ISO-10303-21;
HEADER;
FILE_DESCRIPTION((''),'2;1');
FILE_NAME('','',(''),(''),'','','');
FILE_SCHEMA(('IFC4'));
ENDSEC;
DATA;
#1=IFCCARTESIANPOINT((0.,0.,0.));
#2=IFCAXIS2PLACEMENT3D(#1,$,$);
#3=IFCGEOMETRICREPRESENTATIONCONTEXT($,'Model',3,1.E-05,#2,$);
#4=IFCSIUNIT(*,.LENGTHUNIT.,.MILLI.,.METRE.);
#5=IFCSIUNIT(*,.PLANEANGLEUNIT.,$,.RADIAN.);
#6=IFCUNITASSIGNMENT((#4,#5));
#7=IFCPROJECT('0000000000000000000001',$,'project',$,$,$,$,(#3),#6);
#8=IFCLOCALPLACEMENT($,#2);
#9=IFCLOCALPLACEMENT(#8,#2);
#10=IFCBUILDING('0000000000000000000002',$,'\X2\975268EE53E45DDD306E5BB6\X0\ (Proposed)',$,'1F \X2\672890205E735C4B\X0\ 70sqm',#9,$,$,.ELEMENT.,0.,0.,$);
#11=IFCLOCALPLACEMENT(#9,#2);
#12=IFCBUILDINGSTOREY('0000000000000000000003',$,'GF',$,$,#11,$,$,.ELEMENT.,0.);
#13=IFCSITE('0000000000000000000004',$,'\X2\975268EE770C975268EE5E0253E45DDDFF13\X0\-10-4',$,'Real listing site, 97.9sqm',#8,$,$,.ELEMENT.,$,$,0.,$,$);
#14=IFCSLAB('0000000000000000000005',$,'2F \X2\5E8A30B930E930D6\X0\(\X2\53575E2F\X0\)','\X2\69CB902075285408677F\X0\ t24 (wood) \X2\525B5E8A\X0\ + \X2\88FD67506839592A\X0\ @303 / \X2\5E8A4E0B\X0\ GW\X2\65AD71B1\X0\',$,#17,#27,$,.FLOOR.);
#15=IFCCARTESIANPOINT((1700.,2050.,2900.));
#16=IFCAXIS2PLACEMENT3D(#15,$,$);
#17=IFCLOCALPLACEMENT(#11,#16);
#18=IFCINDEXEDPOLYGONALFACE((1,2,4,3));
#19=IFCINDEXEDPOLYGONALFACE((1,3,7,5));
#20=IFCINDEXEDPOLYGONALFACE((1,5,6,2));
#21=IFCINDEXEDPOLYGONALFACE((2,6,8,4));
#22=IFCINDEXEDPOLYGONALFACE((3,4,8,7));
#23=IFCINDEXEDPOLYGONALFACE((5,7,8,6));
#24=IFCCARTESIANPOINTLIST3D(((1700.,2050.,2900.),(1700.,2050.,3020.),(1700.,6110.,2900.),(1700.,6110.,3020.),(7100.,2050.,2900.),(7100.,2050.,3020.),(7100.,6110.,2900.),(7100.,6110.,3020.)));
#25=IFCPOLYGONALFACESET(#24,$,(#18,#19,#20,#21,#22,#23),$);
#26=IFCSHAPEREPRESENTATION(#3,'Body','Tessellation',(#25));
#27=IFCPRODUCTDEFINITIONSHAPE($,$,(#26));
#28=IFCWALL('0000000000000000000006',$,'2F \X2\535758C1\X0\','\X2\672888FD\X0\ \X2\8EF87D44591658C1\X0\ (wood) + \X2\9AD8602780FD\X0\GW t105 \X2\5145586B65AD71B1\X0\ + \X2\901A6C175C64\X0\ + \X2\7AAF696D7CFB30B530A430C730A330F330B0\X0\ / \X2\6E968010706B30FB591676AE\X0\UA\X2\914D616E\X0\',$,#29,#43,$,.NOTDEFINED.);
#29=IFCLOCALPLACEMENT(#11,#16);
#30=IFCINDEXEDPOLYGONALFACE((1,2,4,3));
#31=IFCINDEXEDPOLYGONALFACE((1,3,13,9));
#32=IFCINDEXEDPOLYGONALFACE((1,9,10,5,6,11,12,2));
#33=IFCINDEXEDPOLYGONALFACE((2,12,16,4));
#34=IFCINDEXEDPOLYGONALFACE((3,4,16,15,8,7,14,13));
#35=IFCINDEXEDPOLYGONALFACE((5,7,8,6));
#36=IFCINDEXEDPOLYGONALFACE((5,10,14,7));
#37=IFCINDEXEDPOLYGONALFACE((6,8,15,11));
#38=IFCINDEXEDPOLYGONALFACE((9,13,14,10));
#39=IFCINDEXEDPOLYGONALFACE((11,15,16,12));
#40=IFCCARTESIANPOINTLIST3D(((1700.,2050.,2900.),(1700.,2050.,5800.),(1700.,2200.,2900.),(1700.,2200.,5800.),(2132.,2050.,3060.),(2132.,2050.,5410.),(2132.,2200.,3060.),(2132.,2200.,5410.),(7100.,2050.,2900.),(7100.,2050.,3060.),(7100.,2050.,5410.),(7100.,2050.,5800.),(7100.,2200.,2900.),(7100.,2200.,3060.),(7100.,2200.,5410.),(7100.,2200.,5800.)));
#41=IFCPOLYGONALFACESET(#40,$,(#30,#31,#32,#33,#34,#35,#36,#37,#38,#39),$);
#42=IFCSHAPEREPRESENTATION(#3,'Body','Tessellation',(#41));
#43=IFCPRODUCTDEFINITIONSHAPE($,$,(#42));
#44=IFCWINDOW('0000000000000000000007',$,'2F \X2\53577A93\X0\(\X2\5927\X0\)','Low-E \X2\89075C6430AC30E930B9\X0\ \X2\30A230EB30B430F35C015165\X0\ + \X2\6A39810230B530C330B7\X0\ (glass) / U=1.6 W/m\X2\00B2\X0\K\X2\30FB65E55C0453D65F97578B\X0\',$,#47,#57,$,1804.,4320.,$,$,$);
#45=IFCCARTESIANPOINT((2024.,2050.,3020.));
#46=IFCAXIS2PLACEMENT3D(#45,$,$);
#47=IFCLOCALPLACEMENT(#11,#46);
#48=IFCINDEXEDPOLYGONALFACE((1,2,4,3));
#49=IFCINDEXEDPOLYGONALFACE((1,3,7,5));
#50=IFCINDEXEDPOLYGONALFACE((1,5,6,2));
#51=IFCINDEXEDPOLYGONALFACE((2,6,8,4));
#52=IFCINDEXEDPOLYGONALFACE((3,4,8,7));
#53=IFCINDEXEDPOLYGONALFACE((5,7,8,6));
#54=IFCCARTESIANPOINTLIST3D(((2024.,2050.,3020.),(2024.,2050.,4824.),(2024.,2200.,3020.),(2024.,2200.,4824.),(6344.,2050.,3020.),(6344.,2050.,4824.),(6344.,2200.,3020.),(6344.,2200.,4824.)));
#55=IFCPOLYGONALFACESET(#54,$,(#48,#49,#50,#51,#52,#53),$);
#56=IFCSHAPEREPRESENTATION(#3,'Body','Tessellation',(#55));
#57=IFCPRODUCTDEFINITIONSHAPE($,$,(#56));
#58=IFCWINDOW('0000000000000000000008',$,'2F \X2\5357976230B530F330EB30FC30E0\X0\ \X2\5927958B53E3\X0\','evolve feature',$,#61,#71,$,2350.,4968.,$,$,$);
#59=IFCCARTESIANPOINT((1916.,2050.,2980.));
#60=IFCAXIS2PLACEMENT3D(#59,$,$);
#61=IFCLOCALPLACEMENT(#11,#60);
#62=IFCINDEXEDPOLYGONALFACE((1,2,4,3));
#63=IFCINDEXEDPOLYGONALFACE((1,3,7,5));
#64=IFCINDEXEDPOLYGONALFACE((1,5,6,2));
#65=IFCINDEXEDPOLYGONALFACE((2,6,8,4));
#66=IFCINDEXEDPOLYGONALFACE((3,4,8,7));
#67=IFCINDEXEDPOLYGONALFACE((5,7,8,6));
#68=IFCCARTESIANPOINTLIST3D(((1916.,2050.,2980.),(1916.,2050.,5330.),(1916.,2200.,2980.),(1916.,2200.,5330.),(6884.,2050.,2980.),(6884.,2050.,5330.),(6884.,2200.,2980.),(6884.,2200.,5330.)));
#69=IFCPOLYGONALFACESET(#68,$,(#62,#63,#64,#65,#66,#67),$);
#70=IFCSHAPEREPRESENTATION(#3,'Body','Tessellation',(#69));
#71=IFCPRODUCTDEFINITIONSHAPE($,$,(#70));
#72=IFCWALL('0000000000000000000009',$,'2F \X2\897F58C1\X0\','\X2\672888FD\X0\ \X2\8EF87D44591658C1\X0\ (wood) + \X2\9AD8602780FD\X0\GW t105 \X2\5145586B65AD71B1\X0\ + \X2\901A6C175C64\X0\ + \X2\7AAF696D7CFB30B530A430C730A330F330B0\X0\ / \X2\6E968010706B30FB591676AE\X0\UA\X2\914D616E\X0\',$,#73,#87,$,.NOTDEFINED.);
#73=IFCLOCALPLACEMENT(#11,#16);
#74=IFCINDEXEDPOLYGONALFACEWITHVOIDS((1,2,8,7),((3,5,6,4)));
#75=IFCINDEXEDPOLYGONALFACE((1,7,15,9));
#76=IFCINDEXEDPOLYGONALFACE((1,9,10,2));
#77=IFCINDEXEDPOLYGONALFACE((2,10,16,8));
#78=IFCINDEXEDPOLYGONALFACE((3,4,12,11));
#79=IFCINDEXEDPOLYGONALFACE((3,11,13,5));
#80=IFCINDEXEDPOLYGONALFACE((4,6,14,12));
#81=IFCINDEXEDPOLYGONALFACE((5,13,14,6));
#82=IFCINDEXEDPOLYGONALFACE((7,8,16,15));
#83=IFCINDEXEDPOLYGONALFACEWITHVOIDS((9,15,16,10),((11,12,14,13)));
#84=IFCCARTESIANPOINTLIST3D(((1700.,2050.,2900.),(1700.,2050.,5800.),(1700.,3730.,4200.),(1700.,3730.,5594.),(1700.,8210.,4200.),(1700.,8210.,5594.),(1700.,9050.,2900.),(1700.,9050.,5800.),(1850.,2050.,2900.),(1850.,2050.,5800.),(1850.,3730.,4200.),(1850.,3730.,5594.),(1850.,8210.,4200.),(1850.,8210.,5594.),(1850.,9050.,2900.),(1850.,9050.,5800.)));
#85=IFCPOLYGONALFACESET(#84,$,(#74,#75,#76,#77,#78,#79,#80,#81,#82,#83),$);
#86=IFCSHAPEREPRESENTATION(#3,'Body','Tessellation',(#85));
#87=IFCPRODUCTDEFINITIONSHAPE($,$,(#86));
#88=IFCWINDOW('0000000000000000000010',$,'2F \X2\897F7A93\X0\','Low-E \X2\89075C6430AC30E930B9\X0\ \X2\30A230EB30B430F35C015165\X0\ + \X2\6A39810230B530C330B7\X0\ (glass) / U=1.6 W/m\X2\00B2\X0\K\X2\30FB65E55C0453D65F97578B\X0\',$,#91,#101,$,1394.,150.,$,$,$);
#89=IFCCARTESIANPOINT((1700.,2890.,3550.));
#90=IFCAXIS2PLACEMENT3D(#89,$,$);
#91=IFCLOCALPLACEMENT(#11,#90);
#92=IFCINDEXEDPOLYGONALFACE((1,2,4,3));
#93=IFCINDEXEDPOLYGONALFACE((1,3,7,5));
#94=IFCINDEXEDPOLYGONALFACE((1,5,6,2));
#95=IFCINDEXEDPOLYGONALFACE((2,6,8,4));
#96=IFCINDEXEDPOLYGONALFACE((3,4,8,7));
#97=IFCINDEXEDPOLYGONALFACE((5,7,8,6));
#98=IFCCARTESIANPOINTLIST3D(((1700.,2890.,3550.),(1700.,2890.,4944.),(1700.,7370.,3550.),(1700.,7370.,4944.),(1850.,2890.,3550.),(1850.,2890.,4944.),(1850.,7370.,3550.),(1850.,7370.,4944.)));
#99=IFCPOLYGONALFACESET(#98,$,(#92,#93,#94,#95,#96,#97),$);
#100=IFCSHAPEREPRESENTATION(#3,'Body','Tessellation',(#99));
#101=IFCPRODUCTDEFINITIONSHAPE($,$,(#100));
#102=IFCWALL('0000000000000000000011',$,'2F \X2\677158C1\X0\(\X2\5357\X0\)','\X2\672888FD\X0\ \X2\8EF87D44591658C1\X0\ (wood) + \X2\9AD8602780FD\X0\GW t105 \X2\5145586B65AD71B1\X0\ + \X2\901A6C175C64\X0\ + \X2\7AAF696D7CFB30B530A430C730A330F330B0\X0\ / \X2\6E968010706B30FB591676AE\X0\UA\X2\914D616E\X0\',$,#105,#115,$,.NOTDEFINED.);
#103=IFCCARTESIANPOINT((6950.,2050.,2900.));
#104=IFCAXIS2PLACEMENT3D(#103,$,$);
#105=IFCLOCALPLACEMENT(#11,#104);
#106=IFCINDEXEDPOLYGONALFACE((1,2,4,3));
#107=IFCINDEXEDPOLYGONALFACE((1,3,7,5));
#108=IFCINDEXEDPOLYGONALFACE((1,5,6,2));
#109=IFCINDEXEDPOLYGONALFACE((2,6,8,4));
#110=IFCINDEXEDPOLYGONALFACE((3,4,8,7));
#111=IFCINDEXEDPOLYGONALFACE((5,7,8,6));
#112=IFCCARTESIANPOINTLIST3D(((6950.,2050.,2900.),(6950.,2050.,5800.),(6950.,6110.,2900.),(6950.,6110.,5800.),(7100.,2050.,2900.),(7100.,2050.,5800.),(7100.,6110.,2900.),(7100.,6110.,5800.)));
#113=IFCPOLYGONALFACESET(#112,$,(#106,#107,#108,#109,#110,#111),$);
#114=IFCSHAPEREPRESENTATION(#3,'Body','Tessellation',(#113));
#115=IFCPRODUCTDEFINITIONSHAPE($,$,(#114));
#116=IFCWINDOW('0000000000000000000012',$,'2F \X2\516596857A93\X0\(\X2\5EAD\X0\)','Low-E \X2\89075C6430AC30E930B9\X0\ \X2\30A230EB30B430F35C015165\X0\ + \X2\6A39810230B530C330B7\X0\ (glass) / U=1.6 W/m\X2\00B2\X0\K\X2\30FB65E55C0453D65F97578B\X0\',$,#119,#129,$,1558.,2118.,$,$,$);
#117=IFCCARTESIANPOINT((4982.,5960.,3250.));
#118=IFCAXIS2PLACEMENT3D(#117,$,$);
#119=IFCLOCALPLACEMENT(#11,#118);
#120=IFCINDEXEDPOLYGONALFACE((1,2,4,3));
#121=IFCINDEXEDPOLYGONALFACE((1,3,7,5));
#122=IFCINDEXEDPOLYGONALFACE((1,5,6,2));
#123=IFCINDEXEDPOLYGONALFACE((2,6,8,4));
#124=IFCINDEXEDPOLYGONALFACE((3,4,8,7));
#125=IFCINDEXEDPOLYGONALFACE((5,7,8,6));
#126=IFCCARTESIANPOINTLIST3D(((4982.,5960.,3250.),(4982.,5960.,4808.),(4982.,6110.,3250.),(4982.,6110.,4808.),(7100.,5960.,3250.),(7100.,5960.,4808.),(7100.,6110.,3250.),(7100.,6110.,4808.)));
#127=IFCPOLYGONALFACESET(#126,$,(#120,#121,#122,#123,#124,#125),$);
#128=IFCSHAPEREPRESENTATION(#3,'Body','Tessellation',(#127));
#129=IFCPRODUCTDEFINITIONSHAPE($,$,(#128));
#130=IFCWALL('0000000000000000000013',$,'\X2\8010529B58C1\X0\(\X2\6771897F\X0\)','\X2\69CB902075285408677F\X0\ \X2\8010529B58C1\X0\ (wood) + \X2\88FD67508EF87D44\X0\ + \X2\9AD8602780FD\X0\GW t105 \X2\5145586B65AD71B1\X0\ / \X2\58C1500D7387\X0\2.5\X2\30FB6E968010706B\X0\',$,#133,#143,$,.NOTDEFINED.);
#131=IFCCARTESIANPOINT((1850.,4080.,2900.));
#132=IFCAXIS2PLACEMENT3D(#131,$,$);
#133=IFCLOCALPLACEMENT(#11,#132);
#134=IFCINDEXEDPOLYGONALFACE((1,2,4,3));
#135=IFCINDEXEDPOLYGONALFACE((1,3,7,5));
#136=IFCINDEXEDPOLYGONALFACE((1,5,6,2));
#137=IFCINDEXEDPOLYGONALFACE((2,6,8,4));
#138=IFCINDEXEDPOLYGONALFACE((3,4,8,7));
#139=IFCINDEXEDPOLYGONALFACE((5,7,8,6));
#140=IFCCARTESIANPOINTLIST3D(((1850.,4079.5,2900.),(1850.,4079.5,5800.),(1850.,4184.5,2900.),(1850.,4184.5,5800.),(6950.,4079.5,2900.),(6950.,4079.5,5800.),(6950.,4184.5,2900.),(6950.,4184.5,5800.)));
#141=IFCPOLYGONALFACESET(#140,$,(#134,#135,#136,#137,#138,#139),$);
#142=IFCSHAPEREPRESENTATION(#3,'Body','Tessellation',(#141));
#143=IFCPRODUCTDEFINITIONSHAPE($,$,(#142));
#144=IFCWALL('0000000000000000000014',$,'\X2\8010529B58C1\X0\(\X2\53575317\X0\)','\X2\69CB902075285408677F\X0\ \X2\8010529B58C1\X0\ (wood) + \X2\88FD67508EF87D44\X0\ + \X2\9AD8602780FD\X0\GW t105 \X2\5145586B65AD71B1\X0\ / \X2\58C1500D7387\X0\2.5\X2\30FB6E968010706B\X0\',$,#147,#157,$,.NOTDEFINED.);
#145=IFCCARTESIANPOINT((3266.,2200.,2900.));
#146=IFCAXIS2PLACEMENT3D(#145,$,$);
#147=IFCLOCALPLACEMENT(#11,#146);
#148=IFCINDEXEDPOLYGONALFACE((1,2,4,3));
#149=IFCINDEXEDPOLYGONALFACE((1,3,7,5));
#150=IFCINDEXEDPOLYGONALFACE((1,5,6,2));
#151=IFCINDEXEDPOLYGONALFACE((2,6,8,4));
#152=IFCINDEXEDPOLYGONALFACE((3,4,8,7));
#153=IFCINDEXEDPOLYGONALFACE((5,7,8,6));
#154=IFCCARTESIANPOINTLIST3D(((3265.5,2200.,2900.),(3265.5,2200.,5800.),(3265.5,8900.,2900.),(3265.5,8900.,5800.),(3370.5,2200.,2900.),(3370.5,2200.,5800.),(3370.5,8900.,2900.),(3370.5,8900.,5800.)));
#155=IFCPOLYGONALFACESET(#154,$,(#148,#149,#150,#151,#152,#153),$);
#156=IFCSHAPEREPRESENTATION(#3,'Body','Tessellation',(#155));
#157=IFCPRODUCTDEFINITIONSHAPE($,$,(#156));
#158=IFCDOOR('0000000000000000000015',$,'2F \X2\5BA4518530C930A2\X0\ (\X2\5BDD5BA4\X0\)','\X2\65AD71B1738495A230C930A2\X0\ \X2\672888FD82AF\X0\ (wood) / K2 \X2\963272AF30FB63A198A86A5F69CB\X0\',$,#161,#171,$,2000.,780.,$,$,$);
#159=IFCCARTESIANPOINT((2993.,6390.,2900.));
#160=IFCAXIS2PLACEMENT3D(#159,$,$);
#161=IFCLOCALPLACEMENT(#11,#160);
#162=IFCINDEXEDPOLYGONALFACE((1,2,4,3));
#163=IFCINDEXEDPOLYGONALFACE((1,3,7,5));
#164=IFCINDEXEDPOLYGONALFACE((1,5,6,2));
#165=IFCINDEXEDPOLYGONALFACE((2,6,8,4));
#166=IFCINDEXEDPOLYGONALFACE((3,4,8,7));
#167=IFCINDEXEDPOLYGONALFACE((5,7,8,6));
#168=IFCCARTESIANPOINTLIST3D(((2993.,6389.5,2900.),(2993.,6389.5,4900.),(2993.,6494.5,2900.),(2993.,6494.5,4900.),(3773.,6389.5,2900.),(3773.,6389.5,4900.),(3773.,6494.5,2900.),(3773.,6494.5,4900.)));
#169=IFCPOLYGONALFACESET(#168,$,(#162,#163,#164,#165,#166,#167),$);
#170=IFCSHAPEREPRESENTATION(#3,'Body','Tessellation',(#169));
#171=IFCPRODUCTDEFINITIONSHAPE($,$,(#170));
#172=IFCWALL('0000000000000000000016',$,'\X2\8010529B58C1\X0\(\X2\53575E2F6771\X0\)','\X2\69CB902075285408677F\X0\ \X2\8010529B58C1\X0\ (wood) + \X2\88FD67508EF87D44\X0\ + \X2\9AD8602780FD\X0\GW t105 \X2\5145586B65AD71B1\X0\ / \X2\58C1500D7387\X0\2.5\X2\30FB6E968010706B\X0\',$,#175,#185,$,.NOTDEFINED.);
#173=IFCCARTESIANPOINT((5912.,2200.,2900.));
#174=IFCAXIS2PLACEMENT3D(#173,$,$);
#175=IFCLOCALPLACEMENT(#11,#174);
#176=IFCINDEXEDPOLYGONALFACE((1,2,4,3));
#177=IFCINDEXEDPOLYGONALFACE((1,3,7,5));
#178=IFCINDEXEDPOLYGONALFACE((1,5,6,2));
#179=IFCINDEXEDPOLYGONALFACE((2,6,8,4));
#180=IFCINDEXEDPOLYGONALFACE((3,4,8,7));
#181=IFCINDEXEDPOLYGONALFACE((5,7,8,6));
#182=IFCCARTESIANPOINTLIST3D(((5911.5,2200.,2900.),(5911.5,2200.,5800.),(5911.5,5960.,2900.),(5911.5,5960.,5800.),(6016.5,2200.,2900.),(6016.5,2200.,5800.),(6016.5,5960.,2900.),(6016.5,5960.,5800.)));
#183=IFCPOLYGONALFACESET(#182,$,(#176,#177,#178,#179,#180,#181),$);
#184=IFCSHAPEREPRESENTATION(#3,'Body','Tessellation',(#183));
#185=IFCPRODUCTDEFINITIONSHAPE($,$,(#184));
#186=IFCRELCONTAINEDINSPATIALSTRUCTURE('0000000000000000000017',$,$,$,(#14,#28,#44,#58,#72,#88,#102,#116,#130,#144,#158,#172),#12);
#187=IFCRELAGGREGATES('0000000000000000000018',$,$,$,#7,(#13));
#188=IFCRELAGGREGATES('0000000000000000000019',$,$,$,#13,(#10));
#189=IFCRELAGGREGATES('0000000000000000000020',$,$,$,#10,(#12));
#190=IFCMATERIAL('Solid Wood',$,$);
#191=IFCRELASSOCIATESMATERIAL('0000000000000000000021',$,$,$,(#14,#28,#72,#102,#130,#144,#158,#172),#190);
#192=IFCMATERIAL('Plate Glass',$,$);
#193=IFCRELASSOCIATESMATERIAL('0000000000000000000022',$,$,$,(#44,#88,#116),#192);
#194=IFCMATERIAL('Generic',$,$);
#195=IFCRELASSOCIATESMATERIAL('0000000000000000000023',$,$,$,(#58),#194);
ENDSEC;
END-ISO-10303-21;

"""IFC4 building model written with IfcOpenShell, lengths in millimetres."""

from ifc_helpers import new_model, si_unit, frame, frame_2d, origin, place, context, project, spatial, rectangle, extrude, material, element, fill, save


model = new_model("IFC4")

# Units and contexts
model_context = context("Model", 3, precision=1e-05, world=origin())
ifc_project = project(units=[si_unit("LENGTHUNIT", "METRE", prefix="MILLI"), si_unit("PLANEANGLEUNIT", "RADIAN")], contexts=[model_context])

# Site, building, storey
site_placement = place(None, origin())
site = spatial("IfcSite", under=ifc_project, at=site_placement, Name="青森県青森市古川３-10-4", ObjectType="Real listing site, 97.9sqm", CompositionType="ELEMENT", RefElevation=0.0)
building_placement = place(site_placement, origin())
building = spatial("IfcBuilding", under=site, at=building_placement, Name="青森古川の家 (Proposed)", ObjectType="1F 木造平屋 70sqm", CompositionType="ELEMENT", ElevationOfRefHeight=0.0, ElevationOfTerrain=0.0)
storey_placement = place(building_placement, origin())
storey = spatial("IfcBuildingStorey", under=building, at=storey_placement, Name="GF", CompositionType="ELEMENT", Elevation=0.0)

# Slab
ifc_material_1 = material(Name="Solid Wood")
slab_placement = place(storey_placement, frame((1700.0, 2050.0, 2900.0)))
element("IfcSlab", 1, at=slab_placement, inside=storey, material=ifc_material_1, Name="2F 床スラブ(南帯)", Description="構造用合板 t24 (wood) 剛床 + 製材根太 @303 / 床下 GW断熱", PredefinedType="FLOOR", context=model_context, shape_type="SweptSolid", body=[
    extrude(rectangle(XDim=5400.0, YDim=4060.0, at=frame_2d((2700.0, 2030.0))), frame((1700.0, 2050.0, 2900.0)), (0.0, 0.0, 1.0), 120.0),
])

# Wall, openings, windows
wall_1_placement = place(storey_placement, frame((1700.0, 2050.0, 2900.0)))
wall_1 = element("IfcWall", 2, at=wall_1_placement, inside=storey, material=ifc_material_1, Name="2F 南壁", Description="木製 軸組外壁 (wood) + 高性能GW t105 充填断熱 + 通気層 + 窯業系サイディング / 準耐火・外皮UA配慮", PredefinedType="NOTDEFINED", context=model_context, shape_type="SweptSolid", body=[
    extrude(rectangle(XDim=5400.0, YDim=150.0, at=frame_2d((2700.0, 75.0))), frame((1700.0, 2050.0, 2900.0)), (0.0, 0.0, 1.0), 2900.0),
])
opening_1_placement = place(storey_placement, frame((2024.0, 2050.0, 3020.0)))
opening_1 = element("IfcOpeningElement", 3, at=opening_1_placement, cuts=wall_1, PredefinedType="NOTDEFINED", context=model_context, shape_type="SweptSolid", body=[
    extrude(rectangle(XDim=4320.0, YDim=150.0, at=frame_2d((2160.0, 75.0))), frame((2024.0, 2050.0, 3020.0)), (0.0, 0.0, 1.0), 1804.0),
])
opening_2_placement = place(storey_placement, frame((1916.0, 2050.0, 2980.0)))
opening_2 = element("IfcOpeningElement", 4, at=opening_2_placement, cuts=wall_1, PredefinedType="NOTDEFINED", context=model_context, shape_type="SweptSolid", body=[
    extrude(rectangle(XDim=4968.0, YDim=150.0, at=frame_2d((2484.0, 75.0))), frame((1916.0, 2050.0, 2980.0)), (0.0, 0.0, 1.0), 2350.0),
])
ifc_material_2 = material(Name="Plate Glass")
window_1_placement = place(storey_placement, frame((2024.0, 2050.0, 3020.0)))
window_1 = element("IfcWindow", 5, at=window_1_placement, inside=storey, material=ifc_material_2, Name="2F 南窓(大)", Description="Low-E 複層ガラス アルゴン封入 + 樹脂サッシ (glass) / U=1.6 W/m²K・日射取得型", OverallHeight=1804.0, OverallWidth=4320.0, context=model_context, shape_type="SweptSolid", body=[
    extrude(rectangle(XDim=4320.0, YDim=150.0, at=frame_2d((2160.0, 75.0))), frame((2024.0, 2050.0, 3020.0)), (0.0, 0.0, 1.0), 1804.0),
])
fill(opening_1, window_1)
ifc_material_3 = material(Name="Generic")
window_2_placement = place(storey_placement, frame((1916.0, 2050.0, 2980.0)))
window_2 = element("IfcWindow", 6, at=window_2_placement, inside=storey, material=ifc_material_3, Name="2F 南面サンルーム 大開口", Description="evolve feature", OverallHeight=2350.0, OverallWidth=4968.0, context=model_context, shape_type="SweptSolid", body=[
    extrude(rectangle(XDim=4968.0, YDim=150.0, at=frame_2d((2484.0, 75.0))), frame((1916.0, 2050.0, 2980.0)), (0.0, 0.0, 1.0), 2350.0),
])
fill(opening_2, window_2)

# Walls, openings, windows
wall_2_placement = place(storey_placement, frame((1700.0, 2050.0, 2900.0)))
wall_2 = element("IfcWall", 7, at=wall_2_placement, inside=storey, material=ifc_material_1, Name="2F 西壁", Description="木製 軸組外壁 (wood) + 高性能GW t105 充填断熱 + 通気層 + 窯業系サイディング / 準耐火・外皮UA配慮", PredefinedType="NOTDEFINED", context=model_context, shape_type="SweptSolid", body=[
    extrude(rectangle(XDim=150.0, YDim=7000.0, at=frame_2d((75.0, 3500.0))), frame((1700.0, 2050.0, 2900.0)), (0.0, 0.0, 1.0), 2900.0),
])
opening_3_placement = place(storey_placement, frame((1700.0, 2890.0, 3550.0)))
opening_3 = element("IfcOpeningElement", 8, at=opening_3_placement, cuts=wall_2, PredefinedType="NOTDEFINED", context=model_context, shape_type="SweptSolid", body=[
    extrude(rectangle(XDim=150.0, YDim=4480.0, at=frame_2d((75.0, 2240.0))), frame((1700.0, 2890.0, 3550.0)), (0.0, 0.0, 1.0), 1394.0),
])
window_3_placement = place(storey_placement, frame((1700.0, 2890.0, 3550.0)))
window_3 = element("IfcWindow", 9, at=window_3_placement, inside=storey, material=ifc_material_2, Name="2F 西窓", Description="Low-E 複層ガラス アルゴン封入 + 樹脂サッシ (glass) / U=1.6 W/m²K・日射取得型", OverallHeight=1394.0, OverallWidth=150.0, context=model_context, shape_type="SweptSolid", body=[
    extrude(rectangle(XDim=150.0, YDim=4480.0, at=frame_2d((75.0, 2240.0))), frame((1700.0, 2890.0, 3550.0)), (0.0, 0.0, 1.0), 1394.0),
])
fill(opening_3, window_3)
wall_3_placement = place(storey_placement, frame((6950.0, 2050.0, 2900.0)))
wall_3 = element("IfcWall", 10, at=wall_3_placement, inside=storey, material=ifc_material_1, Name="2F 東壁(南)", Description="木製 軸組外壁 (wood) + 高性能GW t105 充填断熱 + 通気層 + 窯業系サイディング / 準耐火・外皮UA配慮", PredefinedType="NOTDEFINED", context=model_context, shape_type="SweptSolid", body=[
    extrude(rectangle(XDim=150.0, YDim=4060.0, at=frame_2d((75.0, 2030.0))), frame((6950.0, 2050.0, 2900.0)), (0.0, 0.0, 1.0), 2900.0),
])
opening_4_placement = place(storey_placement, frame((4982.0, 5960.0, 3250.0)))
opening_4 = element("IfcOpeningElement", 11, at=opening_4_placement, cuts=wall_3, PredefinedType="NOTDEFINED", context=model_context, shape_type="SweptSolid", body=[
    extrude(rectangle(XDim=2118.0, YDim=150.0, at=frame_2d((1059.0, 75.0))), frame((4982.0, 5960.0, 3250.0)), (0.0, 0.0, 1.0), 1558.0),
])
window_4_placement = place(storey_placement, frame((4982.0, 5960.0, 3250.0)))
window_4 = element("IfcWindow", 12, at=window_4_placement, inside=storey, material=ifc_material_2, Name="2F 入隅窓(庭)", Description="Low-E 複層ガラス アルゴン封入 + 樹脂サッシ (glass) / U=1.6 W/m²K・日射取得型", OverallHeight=1558.0, OverallWidth=2118.0, context=model_context, shape_type="SweptSolid", body=[
    extrude(rectangle(XDim=2118.0, YDim=150.0, at=frame_2d((1059.0, 75.0))), frame((4982.0, 5960.0, 3250.0)), (0.0, 0.0, 1.0), 1558.0),
])
fill(opening_4, window_4)

# Wall
wall_4_placement = place(storey_placement, frame((1850.0, 4080.0, 2900.0)))
element("IfcWall", 13, at=wall_4_placement, inside=storey, material=ifc_material_1, Name="耐力壁(東西)", Description="構造用合板 耐力壁 (wood) + 製材軸組 + 高性能GW t105 充填断熱 / 壁倍率2.5・準耐火", PredefinedType="NOTDEFINED", context=model_context, shape_type="SweptSolid", body=[
    extrude(rectangle(XDim=5100.0, YDim=105.0, at=frame_2d((2550.0, 52.0))), frame((1850.0, 4080.0, 2900.0)), (0.0, 0.0, 1.0), 2900.0),
])

# Wall, opening, door
wall_5_placement = place(storey_placement, frame((3266.0, 2200.0, 2900.0)))
wall_5 = element("IfcWall", 14, at=wall_5_placement, inside=storey, material=ifc_material_1, Name="耐力壁(南北)", Description="構造用合板 耐力壁 (wood) + 製材軸組 + 高性能GW t105 充填断熱 / 壁倍率2.5・準耐火", PredefinedType="NOTDEFINED", context=model_context, shape_type="SweptSolid", body=[
    extrude(rectangle(XDim=105.0, YDim=6700.0, at=frame_2d((52.0, 3350.0))), frame((3266.0, 2200.0, 2900.0)), (0.0, 0.0, 1.0), 2900.0),
])
opening_5_placement = place(storey_placement, frame((2993.0, 6390.0, 2900.0)))
opening_5 = element("IfcOpeningElement", 15, at=opening_5_placement, cuts=wall_5, PredefinedType="NOTDEFINED", context=model_context, shape_type="SweptSolid", body=[
    extrude(rectangle(XDim=780.0, YDim=105.0, at=frame_2d((390.0, 52.0))), frame((2993.0, 6390.0, 2900.0)), (0.0, 0.0, 1.0), 2000.0),
])
door_placement = place(storey_placement, frame((2993.0, 6390.0, 2900.0)))
door = element("IfcDoor", 16, at=door_placement, inside=storey, material=ifc_material_1, Name="2F 室内ドア (寝室)", Description="断熱玄関ドア 木製芯 (wood) / K2 防犯・採風機構", OverallHeight=2000.0, OverallWidth=780.0, context=model_context, shape_type="SweptSolid", body=[
    extrude(rectangle(XDim=780.0, YDim=105.0, at=frame_2d((390.0, 52.0))), frame((2993.0, 6390.0, 2900.0)), (0.0, 0.0, 1.0), 2000.0),
])
fill(opening_5, door)

# Wall
wall_6_placement = place(storey_placement, frame((5912.0, 2200.0, 2900.0)))
element("IfcWall", 17, at=wall_6_placement, inside=storey, material=ifc_material_1, Name="耐力壁(南帯東)", Description="構造用合板 耐力壁 (wood) + 製材軸組 + 高性能GW t105 充填断熱 / 壁倍率2.5・準耐火", PredefinedType="NOTDEFINED", context=model_context, shape_type="SweptSolid", body=[
    extrude(rectangle(XDim=105.0, YDim=3760.0, at=frame_2d((52.0, 1880.0))), frame((5912.0, 2200.0, 2900.0)), (0.0, 0.0, 1.0), 2900.0),
])

save(model, "model.ifc")
